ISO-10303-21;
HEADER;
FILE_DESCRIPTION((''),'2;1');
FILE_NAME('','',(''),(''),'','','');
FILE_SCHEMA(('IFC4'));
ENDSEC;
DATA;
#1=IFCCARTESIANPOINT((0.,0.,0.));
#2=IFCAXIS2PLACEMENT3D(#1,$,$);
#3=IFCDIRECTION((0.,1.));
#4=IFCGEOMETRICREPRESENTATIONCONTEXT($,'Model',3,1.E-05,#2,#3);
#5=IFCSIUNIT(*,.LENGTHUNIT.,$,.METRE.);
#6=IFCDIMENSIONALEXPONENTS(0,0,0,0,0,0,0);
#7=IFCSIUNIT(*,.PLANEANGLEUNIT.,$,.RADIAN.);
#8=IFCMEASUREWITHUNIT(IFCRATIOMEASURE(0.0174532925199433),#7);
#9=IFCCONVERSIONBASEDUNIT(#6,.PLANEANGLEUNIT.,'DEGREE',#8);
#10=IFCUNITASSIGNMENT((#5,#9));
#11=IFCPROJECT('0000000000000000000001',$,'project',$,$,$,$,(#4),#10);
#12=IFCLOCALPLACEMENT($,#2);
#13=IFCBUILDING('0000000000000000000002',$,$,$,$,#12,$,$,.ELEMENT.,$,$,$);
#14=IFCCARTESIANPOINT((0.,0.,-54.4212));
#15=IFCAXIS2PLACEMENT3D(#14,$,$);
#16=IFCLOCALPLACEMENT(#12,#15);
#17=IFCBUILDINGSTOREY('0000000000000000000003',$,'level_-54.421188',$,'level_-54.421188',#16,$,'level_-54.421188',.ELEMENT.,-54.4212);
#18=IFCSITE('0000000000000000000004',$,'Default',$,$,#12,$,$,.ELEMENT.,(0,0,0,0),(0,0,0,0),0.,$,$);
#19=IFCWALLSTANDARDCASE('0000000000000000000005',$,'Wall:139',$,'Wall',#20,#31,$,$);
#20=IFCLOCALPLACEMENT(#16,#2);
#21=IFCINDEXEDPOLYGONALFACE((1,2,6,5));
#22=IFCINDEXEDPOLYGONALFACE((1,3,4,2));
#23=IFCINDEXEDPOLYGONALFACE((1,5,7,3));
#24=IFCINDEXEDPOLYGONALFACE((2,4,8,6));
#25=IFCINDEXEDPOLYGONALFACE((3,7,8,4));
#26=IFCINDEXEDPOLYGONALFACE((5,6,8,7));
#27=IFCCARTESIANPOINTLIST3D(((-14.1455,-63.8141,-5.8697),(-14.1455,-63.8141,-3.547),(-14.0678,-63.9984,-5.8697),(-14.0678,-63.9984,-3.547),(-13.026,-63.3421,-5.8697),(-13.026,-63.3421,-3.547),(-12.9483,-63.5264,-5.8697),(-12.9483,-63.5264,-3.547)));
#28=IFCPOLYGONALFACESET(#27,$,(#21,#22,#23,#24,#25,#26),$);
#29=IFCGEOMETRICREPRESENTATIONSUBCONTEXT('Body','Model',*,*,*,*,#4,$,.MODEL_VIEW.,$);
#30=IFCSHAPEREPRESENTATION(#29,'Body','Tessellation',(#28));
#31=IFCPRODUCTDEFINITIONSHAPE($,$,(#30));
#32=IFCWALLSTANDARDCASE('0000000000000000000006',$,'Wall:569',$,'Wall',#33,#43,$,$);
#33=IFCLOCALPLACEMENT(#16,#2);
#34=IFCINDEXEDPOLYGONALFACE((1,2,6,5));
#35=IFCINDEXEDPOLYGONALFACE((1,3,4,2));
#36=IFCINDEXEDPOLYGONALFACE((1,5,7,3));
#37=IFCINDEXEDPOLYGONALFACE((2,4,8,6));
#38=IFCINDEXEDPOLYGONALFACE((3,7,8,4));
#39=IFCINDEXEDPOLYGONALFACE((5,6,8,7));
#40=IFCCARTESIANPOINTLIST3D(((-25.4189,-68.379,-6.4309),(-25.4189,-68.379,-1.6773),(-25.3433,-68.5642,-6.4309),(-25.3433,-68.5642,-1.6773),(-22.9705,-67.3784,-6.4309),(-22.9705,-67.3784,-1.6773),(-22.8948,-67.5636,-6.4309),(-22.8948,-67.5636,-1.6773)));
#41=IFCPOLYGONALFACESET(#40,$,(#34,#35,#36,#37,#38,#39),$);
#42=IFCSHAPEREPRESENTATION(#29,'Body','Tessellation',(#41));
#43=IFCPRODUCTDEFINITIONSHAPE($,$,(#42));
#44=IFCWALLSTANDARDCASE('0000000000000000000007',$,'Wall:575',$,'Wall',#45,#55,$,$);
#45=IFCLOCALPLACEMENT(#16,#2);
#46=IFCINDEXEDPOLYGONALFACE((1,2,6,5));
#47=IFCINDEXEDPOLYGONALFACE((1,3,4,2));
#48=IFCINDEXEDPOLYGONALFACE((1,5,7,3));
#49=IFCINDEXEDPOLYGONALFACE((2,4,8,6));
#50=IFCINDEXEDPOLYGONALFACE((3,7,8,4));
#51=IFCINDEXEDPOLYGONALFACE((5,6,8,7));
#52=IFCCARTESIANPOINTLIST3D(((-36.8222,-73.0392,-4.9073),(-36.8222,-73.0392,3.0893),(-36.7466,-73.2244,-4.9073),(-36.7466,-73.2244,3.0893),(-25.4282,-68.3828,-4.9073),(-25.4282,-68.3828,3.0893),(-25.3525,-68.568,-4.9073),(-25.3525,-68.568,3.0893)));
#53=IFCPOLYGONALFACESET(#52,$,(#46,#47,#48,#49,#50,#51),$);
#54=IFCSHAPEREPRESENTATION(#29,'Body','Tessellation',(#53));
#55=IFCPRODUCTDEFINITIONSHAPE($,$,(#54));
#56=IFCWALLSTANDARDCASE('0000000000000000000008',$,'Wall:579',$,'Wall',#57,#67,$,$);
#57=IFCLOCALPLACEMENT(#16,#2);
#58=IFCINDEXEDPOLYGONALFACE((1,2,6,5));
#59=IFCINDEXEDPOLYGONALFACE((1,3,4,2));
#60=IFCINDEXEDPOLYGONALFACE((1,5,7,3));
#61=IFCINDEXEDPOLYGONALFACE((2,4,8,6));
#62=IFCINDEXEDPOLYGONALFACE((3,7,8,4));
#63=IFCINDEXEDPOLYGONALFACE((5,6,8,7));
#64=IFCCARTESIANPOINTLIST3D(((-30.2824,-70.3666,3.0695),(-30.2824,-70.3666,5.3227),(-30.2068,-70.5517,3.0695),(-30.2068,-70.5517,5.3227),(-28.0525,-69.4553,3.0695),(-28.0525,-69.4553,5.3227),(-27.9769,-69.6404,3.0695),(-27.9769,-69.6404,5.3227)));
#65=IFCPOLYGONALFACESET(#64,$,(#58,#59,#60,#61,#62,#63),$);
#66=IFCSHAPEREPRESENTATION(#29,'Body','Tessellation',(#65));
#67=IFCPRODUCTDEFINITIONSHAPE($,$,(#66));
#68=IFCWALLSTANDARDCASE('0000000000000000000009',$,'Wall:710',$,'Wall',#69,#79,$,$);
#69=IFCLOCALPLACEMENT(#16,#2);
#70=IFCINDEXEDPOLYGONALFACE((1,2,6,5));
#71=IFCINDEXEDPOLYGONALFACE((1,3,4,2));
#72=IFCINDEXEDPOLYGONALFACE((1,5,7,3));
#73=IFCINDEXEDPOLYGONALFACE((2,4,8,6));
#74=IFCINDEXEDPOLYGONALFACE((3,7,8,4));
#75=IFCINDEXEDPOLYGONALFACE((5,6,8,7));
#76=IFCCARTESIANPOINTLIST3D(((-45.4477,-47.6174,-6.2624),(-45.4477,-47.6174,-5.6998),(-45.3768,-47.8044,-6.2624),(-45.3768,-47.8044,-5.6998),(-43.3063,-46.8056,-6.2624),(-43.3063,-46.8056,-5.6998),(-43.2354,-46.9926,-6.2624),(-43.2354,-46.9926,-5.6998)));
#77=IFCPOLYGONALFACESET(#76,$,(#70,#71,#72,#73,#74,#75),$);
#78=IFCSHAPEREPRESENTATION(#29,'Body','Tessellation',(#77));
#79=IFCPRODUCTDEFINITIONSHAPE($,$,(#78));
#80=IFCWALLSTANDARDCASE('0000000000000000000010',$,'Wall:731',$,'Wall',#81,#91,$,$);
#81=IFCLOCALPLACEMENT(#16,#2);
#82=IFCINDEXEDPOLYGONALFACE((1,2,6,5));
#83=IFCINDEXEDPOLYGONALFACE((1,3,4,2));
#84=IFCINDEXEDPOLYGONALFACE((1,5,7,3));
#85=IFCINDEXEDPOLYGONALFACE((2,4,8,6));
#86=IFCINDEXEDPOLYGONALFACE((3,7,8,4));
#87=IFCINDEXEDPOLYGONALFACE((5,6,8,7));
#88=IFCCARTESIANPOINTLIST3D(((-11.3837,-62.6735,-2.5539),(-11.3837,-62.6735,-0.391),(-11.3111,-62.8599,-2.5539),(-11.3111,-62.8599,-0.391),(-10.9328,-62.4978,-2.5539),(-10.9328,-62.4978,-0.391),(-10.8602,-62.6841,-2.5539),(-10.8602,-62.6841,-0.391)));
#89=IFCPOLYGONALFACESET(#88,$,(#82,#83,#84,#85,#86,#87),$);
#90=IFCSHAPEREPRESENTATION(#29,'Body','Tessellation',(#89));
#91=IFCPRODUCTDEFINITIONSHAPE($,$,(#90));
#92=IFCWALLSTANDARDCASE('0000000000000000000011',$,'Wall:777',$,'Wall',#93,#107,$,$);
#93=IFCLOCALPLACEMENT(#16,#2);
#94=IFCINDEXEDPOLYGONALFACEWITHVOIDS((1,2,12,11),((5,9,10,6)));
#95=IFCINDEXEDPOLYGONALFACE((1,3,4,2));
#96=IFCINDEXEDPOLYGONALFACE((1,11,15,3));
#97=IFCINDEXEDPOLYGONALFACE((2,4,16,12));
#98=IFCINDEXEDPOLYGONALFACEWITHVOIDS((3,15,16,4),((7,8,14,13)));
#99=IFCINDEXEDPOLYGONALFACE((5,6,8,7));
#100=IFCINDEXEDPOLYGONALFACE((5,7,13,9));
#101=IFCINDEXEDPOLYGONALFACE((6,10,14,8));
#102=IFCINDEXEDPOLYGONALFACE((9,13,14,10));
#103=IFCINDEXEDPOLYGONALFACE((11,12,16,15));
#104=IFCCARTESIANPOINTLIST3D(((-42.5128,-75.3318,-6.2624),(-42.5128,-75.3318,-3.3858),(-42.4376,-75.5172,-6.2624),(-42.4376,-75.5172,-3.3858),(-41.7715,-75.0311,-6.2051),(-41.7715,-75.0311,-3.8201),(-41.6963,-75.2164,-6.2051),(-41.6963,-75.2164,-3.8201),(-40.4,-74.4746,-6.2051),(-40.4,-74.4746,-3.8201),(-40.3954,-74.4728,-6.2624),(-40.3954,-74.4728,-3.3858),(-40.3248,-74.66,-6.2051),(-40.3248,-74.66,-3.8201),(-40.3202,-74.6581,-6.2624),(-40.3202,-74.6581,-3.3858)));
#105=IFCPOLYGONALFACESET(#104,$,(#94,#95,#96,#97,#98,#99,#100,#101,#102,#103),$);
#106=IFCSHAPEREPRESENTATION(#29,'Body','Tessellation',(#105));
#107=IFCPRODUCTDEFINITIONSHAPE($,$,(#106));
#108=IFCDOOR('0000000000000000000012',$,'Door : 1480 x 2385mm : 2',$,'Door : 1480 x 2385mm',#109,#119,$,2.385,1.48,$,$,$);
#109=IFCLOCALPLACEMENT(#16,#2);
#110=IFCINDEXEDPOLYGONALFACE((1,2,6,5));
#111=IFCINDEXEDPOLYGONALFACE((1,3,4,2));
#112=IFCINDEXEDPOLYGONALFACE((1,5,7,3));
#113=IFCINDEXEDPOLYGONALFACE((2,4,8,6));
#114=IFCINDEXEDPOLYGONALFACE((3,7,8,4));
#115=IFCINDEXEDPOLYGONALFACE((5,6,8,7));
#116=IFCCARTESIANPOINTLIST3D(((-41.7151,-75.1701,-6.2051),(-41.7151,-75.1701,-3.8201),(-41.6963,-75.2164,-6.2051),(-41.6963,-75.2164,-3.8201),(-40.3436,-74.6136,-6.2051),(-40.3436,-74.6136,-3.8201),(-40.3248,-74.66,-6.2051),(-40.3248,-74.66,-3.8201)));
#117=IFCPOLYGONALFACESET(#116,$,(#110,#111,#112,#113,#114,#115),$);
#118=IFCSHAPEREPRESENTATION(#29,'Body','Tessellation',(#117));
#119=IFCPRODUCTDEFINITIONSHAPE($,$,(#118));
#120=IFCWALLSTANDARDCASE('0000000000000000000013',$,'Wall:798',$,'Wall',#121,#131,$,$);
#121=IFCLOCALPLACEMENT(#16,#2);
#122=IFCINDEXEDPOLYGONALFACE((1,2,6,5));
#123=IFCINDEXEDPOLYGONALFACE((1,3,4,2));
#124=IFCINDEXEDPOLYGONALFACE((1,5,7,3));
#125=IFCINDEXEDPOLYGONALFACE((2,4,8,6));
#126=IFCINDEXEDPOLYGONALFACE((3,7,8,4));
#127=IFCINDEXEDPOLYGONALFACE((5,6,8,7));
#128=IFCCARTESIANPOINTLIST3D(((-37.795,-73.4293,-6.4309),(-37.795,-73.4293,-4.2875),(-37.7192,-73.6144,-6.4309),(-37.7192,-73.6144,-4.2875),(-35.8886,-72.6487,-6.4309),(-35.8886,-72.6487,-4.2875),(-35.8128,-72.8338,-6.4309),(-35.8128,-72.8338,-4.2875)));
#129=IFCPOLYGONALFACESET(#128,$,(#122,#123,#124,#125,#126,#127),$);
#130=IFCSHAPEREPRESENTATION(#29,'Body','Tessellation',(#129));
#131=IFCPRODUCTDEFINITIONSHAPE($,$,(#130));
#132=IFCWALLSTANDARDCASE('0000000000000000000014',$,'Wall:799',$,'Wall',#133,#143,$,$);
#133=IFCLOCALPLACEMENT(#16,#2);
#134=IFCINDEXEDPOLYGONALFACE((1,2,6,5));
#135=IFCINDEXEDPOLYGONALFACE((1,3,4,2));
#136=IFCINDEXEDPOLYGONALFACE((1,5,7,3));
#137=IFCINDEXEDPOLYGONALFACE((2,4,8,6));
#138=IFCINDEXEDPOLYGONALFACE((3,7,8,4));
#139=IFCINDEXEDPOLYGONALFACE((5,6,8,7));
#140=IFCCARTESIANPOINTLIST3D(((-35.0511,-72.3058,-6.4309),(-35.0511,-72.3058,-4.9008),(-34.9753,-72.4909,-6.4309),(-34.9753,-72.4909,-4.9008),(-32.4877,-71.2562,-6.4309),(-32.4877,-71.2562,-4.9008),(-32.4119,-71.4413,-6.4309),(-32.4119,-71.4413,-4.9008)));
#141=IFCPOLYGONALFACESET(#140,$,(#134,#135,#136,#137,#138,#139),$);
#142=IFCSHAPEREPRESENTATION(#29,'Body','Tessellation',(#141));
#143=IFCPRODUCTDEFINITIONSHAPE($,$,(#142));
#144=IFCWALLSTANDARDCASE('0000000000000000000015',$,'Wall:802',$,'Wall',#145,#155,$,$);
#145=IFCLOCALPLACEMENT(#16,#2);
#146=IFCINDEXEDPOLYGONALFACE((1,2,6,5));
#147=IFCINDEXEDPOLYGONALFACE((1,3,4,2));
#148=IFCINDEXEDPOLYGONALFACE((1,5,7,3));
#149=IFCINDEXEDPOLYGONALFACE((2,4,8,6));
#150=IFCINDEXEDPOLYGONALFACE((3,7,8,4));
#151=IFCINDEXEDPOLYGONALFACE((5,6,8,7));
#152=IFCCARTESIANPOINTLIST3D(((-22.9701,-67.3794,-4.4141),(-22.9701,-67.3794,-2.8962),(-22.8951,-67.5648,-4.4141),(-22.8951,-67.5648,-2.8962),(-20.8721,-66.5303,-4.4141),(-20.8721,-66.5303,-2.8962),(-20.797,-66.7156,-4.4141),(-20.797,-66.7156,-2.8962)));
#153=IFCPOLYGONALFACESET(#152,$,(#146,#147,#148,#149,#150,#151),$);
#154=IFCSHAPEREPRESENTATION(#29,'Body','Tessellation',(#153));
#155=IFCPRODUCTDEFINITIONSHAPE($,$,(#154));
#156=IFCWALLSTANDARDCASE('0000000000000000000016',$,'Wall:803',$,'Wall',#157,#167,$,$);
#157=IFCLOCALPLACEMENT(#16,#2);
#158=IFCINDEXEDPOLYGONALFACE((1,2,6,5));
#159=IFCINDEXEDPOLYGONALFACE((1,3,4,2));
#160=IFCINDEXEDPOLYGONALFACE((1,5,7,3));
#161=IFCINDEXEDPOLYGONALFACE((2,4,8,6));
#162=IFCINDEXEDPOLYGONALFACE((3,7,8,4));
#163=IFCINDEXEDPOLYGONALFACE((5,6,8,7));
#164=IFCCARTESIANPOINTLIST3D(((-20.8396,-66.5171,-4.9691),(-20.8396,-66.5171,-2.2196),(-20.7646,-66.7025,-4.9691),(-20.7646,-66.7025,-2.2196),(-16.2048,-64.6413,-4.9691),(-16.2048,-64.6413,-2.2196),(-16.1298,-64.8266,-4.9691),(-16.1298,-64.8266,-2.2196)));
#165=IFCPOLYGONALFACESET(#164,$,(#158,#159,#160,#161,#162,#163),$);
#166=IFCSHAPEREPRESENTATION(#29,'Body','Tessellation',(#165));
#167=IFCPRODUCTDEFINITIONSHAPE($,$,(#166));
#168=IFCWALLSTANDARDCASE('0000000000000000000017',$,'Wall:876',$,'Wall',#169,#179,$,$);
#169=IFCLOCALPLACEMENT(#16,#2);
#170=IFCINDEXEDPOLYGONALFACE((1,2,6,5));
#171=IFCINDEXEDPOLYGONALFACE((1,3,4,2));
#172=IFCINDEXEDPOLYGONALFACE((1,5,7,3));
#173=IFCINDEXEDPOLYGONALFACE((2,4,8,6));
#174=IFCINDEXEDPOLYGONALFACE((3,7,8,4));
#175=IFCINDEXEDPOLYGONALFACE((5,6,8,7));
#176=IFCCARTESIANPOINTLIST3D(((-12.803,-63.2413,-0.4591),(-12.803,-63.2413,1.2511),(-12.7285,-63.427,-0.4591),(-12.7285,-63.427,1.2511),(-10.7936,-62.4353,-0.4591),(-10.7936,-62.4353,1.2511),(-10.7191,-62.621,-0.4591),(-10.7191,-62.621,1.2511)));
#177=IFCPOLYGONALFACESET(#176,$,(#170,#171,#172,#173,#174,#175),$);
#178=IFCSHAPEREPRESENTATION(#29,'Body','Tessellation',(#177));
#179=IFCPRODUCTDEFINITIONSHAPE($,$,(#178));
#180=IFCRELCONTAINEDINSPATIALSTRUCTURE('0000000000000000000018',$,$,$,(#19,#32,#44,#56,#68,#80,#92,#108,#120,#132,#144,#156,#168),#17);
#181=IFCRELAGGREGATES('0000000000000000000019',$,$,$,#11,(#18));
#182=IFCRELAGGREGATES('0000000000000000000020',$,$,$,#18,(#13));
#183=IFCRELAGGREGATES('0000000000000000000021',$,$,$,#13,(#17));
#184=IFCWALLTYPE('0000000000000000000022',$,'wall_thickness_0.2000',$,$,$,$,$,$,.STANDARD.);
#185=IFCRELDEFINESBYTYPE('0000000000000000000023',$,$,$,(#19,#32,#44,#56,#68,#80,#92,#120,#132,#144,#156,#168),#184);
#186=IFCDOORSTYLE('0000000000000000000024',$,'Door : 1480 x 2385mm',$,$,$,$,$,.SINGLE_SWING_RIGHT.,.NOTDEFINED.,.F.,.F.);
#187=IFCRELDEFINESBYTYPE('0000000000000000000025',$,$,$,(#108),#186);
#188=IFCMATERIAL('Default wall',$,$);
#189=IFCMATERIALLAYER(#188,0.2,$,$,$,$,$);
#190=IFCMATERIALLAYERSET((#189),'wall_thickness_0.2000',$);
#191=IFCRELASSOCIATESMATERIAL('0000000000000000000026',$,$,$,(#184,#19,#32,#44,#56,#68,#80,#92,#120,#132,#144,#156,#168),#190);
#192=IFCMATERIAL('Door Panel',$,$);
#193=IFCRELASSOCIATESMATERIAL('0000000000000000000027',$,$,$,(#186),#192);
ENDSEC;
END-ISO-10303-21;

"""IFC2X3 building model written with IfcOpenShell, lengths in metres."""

from ifc_helpers import new_model, entity, si_unit, converted_unit, direction, frame, frame_2d, origin, origin_2d_with_axis, place, context, subcontext, project, spatial, polyline, rectangle, outline, extrude, source, transform, mapped, material, layer, layer_set, layer_usage, type_object, type_shapes, element, fill, save


model = new_model("IFC2X3")

# Units and contexts
model_context = context("Model", 3, precision=1e-05, world=origin(), true_north=direction((0.0, 1.0)))
body_context = subcontext(model_context, "Body", "Model", "MODEL_VIEW")
ifc_project = project(units=[si_unit("LENGTHUNIT", "METRE"), converted_unit("PLANEANGLEUNIT", "DEGREE", entity("IfcRatioMeasure", 0.0174532925199433), si_unit("PLANEANGLEUNIT", "RADIAN"), dimensions=[0, 0, 0, 0, 0, 0, 0])], contexts=[model_context])

# Site, building, storey
placement_1 = place(None, origin())
site = spatial("IfcSite", under=ifc_project, at=placement_1, Name="Default", CompositionType="ELEMENT", RefLatitude=(0, 0, 0, 0), RefLongitude=(0, 0, 0, 0), RefElevation=0.0)
building = spatial("IfcBuilding", under=site, at=placement_1, CompositionType="ELEMENT")
storey_placement = place(placement_1, frame((0.0, 0.0, -54.4212)))
storey = spatial("IfcBuildingStorey", under=building, at=storey_placement, Name="level_-54.421188", ObjectType="level_-54.421188", LongName="level_-54.421188", CompositionType="ELEMENT", Elevation=-54.4212)

# Walls
ifc_material_1 = material(Name="Default wall")
ifc_layer = layer(ifc_material_1, 0.2)
ifc_layer_set = layer_set([ifc_layer], Name="wall_thickness_0.2000")
ifc_layer_usage = layer_usage(ifc_layer_set, "AXIS2", "POSITIVE", -0.1)
wall_type = type_object("IfcWallType", Name="wall_thickness_0.2000", PredefinedType="STANDARD", material=ifc_layer_set)
placement_2 = place(placement_1, frame((0.0, 0.0, -60.2909)))
wall_1_placement = place(placement_2, frame((-14.1067, -63.9063, 0.0), z_axis=(0.0, 0.0, 1.0), x_axis=(0.921452, 0.388493, 0.0)))
element("IfcWallStandardCase", 1, at=wall_1_placement, inside=storey, type_object=wall_type, material=ifc_layer_usage, Name="Wall:139", ObjectType="Wall", context=body_context, shape_type="SweptSolid", body=[
    extrude(outline(polyline([(1.215, -0.1), (1.215, 0.1), (0.0, 0.1), (0.0, -0.1), (1.215, -0.1)])), origin(), (0.0, 0.0, 1.0), 2.3227),
])
placement_3 = place(placement_1, frame((0.0, 0.0, -60.8521)))
wall_2_placement = place(placement_3, frame((-25.3811, -68.4716, 0.0), z_axis=(0.0, 0.0, 1.0), x_axis=(0.925684, 0.378297, 0.0)))
element("IfcWallStandardCase", 2, at=wall_2_placement, inside=storey, type_object=wall_type, material=ifc_layer_usage, Name="Wall:569", ObjectType="Wall", context=body_context, shape_type="SweptSolid", body=[
    extrude(outline(polyline([(2.645, -0.1), (2.645, 0.1), (0.0, 0.1), (0.0, -0.1), (2.645, -0.1)])), origin(), (0.0, 0.0, 1.0), 4.7536),
])
placement_4 = place(placement_1, frame((0.0, 0.0, -59.3285)))
wall_3_placement = place(placement_4, frame((-36.7844, -73.1318, 0.0), z_axis=(0.0, 0.0, 1.0), x_axis=(0.925684, 0.378298, 0.0)))
element("IfcWallStandardCase", 3, at=wall_3_placement, inside=storey, type_object=wall_type, material=ifc_layer_usage, Name="Wall:575", ObjectType="Wall", context=body_context, shape_type="SweptSolid", body=[
    extrude(outline(polyline([(12.3088, -0.1), (12.3088, 0.1), (0.0, 0.1), (0.0, -0.1), (12.3088, -0.1)])), origin(), (0.0, 0.0, 1.0), 7.9967),
])
placement_5 = place(placement_1, frame((0.0, 0.0, -51.3517)))
wall_4_placement = place(placement_5, frame((-30.2446, -70.4592, 0.0), z_axis=(0.0, 0.0, 1.0), x_axis=(0.925683, 0.378299, 0.0)))
element("IfcWallStandardCase", 4, at=wall_4_placement, inside=storey, type_object=wall_type, material=ifc_layer_usage, Name="Wall:579", ObjectType="Wall", context=body_context, shape_type="SweptSolid", body=[
    extrude(outline(polyline([(2.4089, -0.1), (2.4089, 0.1), (0.0, 0.1), (0.0, -0.1), (2.4089, -0.1)])), origin(), (0.0, 0.0, 1.0), 2.2531),
])
placement_6 = place(placement_1, frame((0.0, 0.0, -60.6836)))
wall_5_placement = place(placement_6, frame((-45.4122, -47.7109, 0.0), z_axis=(0.0, 0.0, 1.0), x_axis=(0.935067, 0.35447, 0.0)))
element("IfcWallStandardCase", 5, at=wall_5_placement, inside=storey, type_object=wall_type, material=ifc_layer_usage, Name="Wall:710", ObjectType="Wall", context=body_context, shape_type="SweptSolid", body=[
    extrude(outline(polyline([(2.2901, -0.1), (2.2901, 0.1), (0.0, 0.1), (0.0, -0.1), (2.2901, -0.1)])), origin(), (0.0, 0.0, 1.0), 0.5626),
])
placement_7 = place(placement_1, frame((0.0, 0.0, -56.9751)))
wall_6_placement = place(placement_7, frame((-11.3474, -62.7667, 0.0), z_axis=(0.0, 0.0, 1.0), x_axis=(0.931742, 0.363121, 0.0)))
element("IfcWallStandardCase", 6, at=wall_6_placement, inside=storey, type_object=wall_type, material=ifc_layer_usage, Name="Wall:731", ObjectType="Wall", context=body_context, shape_type="SweptSolid", body=[
    extrude(outline(polyline([(0.4839, -0.1), (0.4839, 0.1), (0.0, 0.1), (0.0, -0.1), (0.4839, -0.1)])), origin(), (0.0, 0.0, 1.0), 2.1629),
])

# Wall, opening, door
placement_8 = place(placement_1, frame((0.0, 0.0, -60.6836)))
wall_7_placement = place(placement_8, frame((-40.3578, -74.5654, 0.0), z_axis=(0.0, 0.0, 1.0), x_axis=(-0.926635, -0.375961, 0.0)))
wall_7 = element("IfcWallStandardCase", 7, at=wall_7_placement, inside=storey, type_object=wall_type, material=ifc_layer_usage, Name="Wall:777", ObjectType="Wall", context=body_context, shape_type="SweptSolid", body=[
    extrude(outline(polyline([(2.285, -0.1), (2.285, 0.1), (0.0, 0.1), (0.0, -0.1), (2.285, -0.1)])), origin(), (0.0, 0.0, 1.0), 2.8765),
])
opening_1_placement = place(wall_7_placement, frame((0.005, -0.1, 0.0573)))
opening_1 = element("IfcOpeningElement", 8, at=opening_1_placement, cuts=wall_7, ObjectType="Opening", context=body_context, shape_type="SweptSolid", body=[
    extrude(rectangle(XDim=1.48, YDim=2.385, at=frame_2d((1.1925, 0.74), x_axis=(0.0, 1.0))), frame((0.0, 0.0, 0.0), z_axis=(0.0, 1.0, 0.0), x_axis=(0.0, 0.0, 1.0)), (0.0, 0.0, 1.0), 0.2),
])
ifc_material_2 = material(Name="Door Panel")
door_style = type_object("IfcDoorStyle", Name="Door : 1480 x 2385mm", ConstructionType="NOTDEFINED", OperationType="SINGLE_SWING_RIGHT", ParameterTakesPrecedence=False, Sizeable=False, material=ifc_material_2)
shared_shape_1 = source(origin(), body_context, "Body", "SweptSolid", [
    extrude(rectangle(XDim=0.05, YDim=1.48, at=origin_2d_with_axis()), frame((0.74, 0.175, 0.0), z_axis=(0.0, 0.0, 1.0), x_axis=(0.0, 1.0, 0.0)), (0.0, 0.0, 1.0), 2.385),
])
type_shapes(door_style, [shared_shape_1])
door_placement = place(opening_1_placement, origin())
door = element("IfcDoor", 9, at=door_placement, inside=storey, type_object=door_style, Name="Door : 1480 x 2385mm : 2", ObjectType="Door : 1480 x 2385mm", OverallHeight=2.385, OverallWidth=1.48, context=body_context, shape_type="MappedRepresentation", body=[
    mapped(shared_shape_1, transform((0.0, 0.0, 0.0), scale=1.0)),
])
fill(opening_1, door)

# Walls
placement_9 = place(placement_1, frame((0.0, 0.0, -60.8521)))
wall_8_placement = place(placement_9, frame((-37.7571, -73.5218, 0.0), z_axis=(0.0, 0.0, 1.0), x_axis=(0.925427, 0.378925, 0.0)))
element("IfcWallStandardCase", 10, at=wall_8_placement, inside=storey, type_object=wall_type, material=ifc_layer_usage, Name="Wall:798", ObjectType="Wall", context=body_context, shape_type="SweptSolid", body=[
    extrude(outline(polyline([(2.06, -0.1), (2.06, 0.1), (0.0, 0.1), (0.0, -0.1), (2.06, -0.1)])), origin(), (0.0, 0.0, 1.0), 2.1434),
])
placement_10 = place(placement_1, frame((0.0, 0.0, -60.8521)))
wall_9_placement = place(placement_10, frame((-35.0132, -72.3983, 0.0), z_axis=(0.0, 0.0, 1.0), x_axis=(0.925428, 0.378922, 0.0)))
element("IfcWallStandardCase", 11, at=wall_9_placement, inside=storey, type_object=wall_type, material=ifc_layer_usage, Name="Wall:799", ObjectType="Wall", context=body_context, shape_type="SweptSolid", body=[
    extrude(outline(polyline([(2.77, -0.1), (2.77, 0.1), (0.0, 0.1), (0.0, -0.1), (2.77, -0.1)])), origin(), (0.0, 0.0, 1.0), 1.5301),
])
placement_11 = place(placement_1, frame((0.0, 0.0, -58.8353)))
wall_10_placement = place(placement_11, frame((-22.9326, -67.4721, 0.0), z_axis=(0.0, 0.0, 1.0), x_axis=(0.926955, 0.375174, 0.0)))
element("IfcWallStandardCase", 12, at=wall_10_placement, inside=storey, type_object=wall_type, material=ifc_layer_usage, Name="Wall:802", ObjectType="Wall", context=body_context, shape_type="SweptSolid", body=[
    extrude(outline(polyline([(2.2634, -0.1), (2.2634, 0.1), (0.0, 0.1), (0.0, -0.1), (2.2634, -0.1)])), origin(), (0.0, 0.0, 1.0), 1.5179),
])
placement_12 = place(placement_1, frame((0.0, 0.0, -59.3903)))
wall_11_placement = place(placement_12, frame((-20.8021, -66.6098, 0.0), z_axis=(0.0, 0.0, 1.0), x_axis=(0.926955, 0.375172, 0.0)))
element("IfcWallStandardCase", 13, at=wall_11_placement, inside=storey, type_object=wall_type, material=ifc_layer_usage, Name="Wall:803", ObjectType="Wall", context=body_context, shape_type="SweptSolid", body=[
    extrude(outline(polyline([(5.0, -0.1), (5.0, 0.1), (0.0, 0.1), (0.0, -0.1), (5.0, -0.1)])), origin(), (0.0, 0.0, 1.0), 2.7496),
])
placement_13 = place(placement_1, frame((0.0, 0.0, -54.8803)))
wall_12_placement = place(placement_13, frame((-10.7564, -62.5282, 0.0), z_axis=(0.0, 0.0, 1.0), x_axis=(-0.92812, -0.372281, 0.0)))
element("IfcWallStandardCase", 14, at=wall_12_placement, inside=storey, type_object=wall_type, material=ifc_layer_usage, Name="Wall:876", ObjectType="Wall", context=body_context, shape_type="SweptSolid", body=[
    extrude(outline(polyline([(2.165, -0.1), (2.165, 0.1), (0.0, 0.1), (0.0, -0.1), (2.165, -0.1)])), origin(), (0.0, 0.0, 1.0), 1.7102),
])

save(model, "model.ifc")
